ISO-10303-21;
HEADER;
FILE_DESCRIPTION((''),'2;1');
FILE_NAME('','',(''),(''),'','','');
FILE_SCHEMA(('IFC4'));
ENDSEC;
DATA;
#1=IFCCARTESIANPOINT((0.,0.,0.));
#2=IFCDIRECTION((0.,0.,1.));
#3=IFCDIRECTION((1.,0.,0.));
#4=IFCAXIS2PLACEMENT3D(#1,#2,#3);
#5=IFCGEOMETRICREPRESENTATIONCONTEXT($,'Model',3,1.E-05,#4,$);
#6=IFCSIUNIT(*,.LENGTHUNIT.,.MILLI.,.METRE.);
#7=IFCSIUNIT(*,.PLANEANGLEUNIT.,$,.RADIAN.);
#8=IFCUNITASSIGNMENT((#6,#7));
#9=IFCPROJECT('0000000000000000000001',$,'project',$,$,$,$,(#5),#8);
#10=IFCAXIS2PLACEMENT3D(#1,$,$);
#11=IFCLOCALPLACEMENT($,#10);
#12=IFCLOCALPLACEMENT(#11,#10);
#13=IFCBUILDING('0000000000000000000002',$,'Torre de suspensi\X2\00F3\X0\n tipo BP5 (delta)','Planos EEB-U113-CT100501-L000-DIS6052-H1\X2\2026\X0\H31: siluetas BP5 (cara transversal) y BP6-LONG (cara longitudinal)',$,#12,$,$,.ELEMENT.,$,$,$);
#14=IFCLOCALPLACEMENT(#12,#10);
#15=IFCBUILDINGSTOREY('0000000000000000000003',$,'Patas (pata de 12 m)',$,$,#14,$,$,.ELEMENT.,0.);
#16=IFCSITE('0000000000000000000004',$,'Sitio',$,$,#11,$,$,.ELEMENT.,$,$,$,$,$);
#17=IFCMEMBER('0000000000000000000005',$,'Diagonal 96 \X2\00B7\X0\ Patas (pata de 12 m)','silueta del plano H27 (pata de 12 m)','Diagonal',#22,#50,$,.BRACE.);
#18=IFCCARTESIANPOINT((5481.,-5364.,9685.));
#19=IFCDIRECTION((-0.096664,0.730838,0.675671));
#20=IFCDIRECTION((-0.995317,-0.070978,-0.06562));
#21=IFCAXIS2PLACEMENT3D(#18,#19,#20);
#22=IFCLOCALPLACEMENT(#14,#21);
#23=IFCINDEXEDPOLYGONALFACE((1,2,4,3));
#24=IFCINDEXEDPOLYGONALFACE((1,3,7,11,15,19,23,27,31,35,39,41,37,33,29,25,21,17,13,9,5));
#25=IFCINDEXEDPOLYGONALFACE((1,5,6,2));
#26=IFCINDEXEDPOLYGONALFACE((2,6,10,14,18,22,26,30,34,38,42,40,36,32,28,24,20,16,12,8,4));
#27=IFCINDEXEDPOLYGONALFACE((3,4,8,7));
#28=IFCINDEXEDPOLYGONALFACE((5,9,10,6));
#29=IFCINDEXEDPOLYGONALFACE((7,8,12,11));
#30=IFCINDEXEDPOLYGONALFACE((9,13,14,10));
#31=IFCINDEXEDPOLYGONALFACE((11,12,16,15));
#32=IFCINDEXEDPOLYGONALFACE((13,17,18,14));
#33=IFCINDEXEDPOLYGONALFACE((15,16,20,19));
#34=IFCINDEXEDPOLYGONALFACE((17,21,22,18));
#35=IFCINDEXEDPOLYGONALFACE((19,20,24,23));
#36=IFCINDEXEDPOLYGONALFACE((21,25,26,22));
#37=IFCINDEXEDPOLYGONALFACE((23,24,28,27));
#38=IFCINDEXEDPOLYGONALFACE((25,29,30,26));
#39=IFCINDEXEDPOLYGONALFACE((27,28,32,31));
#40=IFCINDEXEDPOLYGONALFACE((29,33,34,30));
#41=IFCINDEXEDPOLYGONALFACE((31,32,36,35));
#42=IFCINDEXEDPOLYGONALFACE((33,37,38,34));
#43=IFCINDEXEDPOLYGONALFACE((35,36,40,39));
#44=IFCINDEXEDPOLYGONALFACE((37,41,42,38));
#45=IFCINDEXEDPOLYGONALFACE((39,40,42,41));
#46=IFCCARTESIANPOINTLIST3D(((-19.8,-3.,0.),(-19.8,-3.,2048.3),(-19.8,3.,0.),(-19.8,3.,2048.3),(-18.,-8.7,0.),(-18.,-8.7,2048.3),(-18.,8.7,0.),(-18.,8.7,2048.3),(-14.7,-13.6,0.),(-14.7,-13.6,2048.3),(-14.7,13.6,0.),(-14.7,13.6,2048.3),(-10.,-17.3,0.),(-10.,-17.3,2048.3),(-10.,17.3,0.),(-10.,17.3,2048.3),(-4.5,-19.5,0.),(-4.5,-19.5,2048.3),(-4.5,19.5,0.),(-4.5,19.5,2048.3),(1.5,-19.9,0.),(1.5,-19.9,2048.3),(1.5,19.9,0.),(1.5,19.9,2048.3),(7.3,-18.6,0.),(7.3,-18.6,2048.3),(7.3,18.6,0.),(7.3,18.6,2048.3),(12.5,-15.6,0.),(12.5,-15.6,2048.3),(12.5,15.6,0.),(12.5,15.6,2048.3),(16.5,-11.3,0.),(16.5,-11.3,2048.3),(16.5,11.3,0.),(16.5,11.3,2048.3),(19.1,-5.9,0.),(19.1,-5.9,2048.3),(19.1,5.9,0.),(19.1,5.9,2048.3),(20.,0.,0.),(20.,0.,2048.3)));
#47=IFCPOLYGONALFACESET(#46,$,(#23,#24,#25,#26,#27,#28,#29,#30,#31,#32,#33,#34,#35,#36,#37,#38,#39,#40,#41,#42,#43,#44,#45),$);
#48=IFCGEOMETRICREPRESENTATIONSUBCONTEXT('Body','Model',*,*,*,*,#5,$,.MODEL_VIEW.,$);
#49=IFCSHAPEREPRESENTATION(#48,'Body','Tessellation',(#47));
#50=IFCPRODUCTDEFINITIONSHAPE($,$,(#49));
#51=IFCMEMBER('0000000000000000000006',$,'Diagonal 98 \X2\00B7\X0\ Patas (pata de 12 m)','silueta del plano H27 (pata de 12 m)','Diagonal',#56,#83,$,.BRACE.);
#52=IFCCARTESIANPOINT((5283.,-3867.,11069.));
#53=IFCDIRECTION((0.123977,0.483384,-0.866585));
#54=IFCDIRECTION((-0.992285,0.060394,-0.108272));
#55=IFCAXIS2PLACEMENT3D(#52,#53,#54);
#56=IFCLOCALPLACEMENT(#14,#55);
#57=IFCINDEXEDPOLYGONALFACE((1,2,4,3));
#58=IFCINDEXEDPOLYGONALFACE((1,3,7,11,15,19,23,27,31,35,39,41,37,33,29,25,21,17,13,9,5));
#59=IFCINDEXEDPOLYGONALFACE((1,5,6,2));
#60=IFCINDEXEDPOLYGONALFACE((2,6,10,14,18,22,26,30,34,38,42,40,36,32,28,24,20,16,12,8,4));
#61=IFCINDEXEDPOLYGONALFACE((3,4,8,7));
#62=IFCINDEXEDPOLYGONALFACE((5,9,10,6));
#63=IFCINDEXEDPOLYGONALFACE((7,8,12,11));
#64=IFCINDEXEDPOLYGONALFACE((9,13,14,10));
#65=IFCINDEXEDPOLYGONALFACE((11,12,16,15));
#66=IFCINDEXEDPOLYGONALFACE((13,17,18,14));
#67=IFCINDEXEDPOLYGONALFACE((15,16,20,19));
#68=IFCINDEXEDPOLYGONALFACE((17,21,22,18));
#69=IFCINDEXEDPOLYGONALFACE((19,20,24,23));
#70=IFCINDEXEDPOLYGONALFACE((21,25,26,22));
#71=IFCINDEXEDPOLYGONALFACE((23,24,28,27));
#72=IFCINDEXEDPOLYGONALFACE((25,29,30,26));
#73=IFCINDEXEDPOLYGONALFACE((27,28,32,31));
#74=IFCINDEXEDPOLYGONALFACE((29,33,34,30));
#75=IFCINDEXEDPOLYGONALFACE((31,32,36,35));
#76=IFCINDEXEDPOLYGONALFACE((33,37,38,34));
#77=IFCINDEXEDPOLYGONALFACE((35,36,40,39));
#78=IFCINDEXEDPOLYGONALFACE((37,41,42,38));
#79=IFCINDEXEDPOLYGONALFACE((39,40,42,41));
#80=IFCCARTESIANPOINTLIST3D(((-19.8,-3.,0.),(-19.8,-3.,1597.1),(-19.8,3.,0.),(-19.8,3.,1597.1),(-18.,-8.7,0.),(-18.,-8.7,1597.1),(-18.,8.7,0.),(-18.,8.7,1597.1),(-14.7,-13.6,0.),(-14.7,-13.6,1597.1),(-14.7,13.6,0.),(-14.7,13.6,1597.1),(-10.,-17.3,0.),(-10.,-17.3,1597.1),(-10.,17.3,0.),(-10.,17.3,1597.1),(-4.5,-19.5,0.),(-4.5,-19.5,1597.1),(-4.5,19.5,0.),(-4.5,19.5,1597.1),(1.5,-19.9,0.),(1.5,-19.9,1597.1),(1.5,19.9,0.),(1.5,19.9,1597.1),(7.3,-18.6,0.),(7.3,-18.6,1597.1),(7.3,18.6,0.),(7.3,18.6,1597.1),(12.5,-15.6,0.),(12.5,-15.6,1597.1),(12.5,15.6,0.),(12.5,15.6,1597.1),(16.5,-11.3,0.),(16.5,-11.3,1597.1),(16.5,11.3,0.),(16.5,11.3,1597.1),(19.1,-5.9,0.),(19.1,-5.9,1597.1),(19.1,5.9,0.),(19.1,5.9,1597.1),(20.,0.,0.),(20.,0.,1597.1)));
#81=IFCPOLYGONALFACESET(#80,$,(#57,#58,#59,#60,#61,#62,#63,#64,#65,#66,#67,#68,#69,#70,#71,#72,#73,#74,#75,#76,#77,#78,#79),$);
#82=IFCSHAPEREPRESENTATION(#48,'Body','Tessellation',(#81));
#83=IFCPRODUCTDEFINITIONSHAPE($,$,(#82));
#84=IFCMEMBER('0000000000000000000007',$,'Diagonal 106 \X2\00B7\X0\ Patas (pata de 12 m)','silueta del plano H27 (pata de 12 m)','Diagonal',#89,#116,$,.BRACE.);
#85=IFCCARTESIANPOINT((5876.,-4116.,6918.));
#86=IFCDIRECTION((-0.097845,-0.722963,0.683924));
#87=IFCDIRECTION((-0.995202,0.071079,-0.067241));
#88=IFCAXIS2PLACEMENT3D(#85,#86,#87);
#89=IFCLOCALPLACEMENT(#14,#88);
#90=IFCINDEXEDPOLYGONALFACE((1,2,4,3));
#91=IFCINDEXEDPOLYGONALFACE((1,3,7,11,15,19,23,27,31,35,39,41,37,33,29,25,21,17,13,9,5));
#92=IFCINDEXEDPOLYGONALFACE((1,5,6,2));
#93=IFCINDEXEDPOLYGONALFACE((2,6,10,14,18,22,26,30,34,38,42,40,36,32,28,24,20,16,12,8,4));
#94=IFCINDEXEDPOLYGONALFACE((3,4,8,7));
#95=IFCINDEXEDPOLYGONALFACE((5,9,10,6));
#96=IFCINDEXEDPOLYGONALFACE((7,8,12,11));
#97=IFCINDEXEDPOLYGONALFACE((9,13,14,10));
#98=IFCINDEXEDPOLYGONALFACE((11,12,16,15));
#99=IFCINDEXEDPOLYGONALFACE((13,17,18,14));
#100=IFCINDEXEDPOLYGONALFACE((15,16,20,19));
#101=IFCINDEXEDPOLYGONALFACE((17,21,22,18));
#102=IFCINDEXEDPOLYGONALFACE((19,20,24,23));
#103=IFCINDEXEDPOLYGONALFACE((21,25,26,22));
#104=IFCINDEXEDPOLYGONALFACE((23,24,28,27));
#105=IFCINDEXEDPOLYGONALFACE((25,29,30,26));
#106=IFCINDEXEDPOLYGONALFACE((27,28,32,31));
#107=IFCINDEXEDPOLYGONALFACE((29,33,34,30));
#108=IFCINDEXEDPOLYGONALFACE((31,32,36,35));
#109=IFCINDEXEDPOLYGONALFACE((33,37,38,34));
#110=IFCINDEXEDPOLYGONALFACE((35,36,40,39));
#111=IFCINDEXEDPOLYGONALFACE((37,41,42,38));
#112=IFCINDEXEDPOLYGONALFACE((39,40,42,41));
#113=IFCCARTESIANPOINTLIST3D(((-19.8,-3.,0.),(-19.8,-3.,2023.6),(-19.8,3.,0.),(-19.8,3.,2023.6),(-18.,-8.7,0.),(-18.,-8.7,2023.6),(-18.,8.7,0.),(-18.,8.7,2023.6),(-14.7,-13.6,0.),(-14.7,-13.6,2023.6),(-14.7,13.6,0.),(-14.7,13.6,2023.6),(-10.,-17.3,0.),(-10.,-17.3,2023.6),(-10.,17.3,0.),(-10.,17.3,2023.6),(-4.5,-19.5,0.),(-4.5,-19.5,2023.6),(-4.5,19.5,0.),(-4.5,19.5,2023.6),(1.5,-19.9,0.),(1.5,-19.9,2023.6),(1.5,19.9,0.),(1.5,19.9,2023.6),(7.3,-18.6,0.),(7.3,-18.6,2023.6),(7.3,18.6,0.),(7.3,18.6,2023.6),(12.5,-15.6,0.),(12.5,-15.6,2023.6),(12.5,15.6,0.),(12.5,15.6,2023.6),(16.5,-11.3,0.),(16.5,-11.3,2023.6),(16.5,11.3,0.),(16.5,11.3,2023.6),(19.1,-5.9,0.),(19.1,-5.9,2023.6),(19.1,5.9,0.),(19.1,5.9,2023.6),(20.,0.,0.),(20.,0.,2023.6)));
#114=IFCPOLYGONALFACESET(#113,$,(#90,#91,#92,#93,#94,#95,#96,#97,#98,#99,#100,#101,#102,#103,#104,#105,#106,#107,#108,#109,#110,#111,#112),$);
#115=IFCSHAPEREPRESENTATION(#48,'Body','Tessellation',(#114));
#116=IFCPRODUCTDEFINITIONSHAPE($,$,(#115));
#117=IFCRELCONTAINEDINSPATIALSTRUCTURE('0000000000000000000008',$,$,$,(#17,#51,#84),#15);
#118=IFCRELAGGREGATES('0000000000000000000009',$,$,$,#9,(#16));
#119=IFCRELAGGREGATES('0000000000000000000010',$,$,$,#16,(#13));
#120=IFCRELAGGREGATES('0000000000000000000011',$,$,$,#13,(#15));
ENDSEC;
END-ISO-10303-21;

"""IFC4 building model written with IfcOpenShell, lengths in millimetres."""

from ifc_helpers import new_model, si_unit, frame, origin, origin_with_axes, place, context, subcontext, project, spatial, circle, extrude, element, save


model = new_model("IFC4")

# Units and contexts
model_context = context("Model", 3, precision=1e-05, world=origin_with_axes())
body_context = subcontext(model_context, "Body", "Model", "MODEL_VIEW")
ifc_project = project(units=[si_unit("LENGTHUNIT", "METRE", prefix="MILLI"), si_unit("PLANEANGLEUNIT", "RADIAN")], contexts=[model_context])

# Site, building, storey
site_placement = place(None, origin())
site = spatial("IfcSite", under=ifc_project, at=site_placement, Name="Sitio", CompositionType="ELEMENT")
building_placement = place(site_placement, origin())
building = spatial("IfcBuilding", under=site, at=building_placement, Name="Torre de suspensión tipo BP5 (delta)", Description="Planos EEB-U113-CT100501-L000-DIS6052-H1…H31: siluetas BP5 (cara transversal) y BP6-LONG (cara longitudinal)", CompositionType="ELEMENT")
storey_placement = place(building_placement, origin())
storey = spatial("IfcBuildingStorey", under=building, at=storey_placement, Name="Patas (pata de 12 m)", CompositionType="ELEMENT", Elevation=0.0)

# Members
member_1_placement = place(storey_placement, frame((5481.0, -5364.0, 9685.0), z_axis=(-0.096664, 0.730838, 0.675671), x_axis=(-0.995317, -0.070978, -0.06562)))
element("IfcMember", 1, at=member_1_placement, inside=storey, Name="Diagonal 96 · Patas (pata de 12 m)", Description="silueta del plano H27 (pata de 12 m)", ObjectType="Diagonal", PredefinedType="BRACE", context=body_context, shape_type="SweptSolid", body=[
    extrude(circle(Radius=20.0), None, (0.0, 0.0, 1.0), 2048.3),
])
member_2_placement = place(storey_placement, frame((5283.0, -3867.0, 11069.0), z_axis=(0.123977, 0.483384, -0.866585), x_axis=(-0.992285, 0.060394, -0.108272)))
element("IfcMember", 2, at=member_2_placement, inside=storey, Name="Diagonal 98 · Patas (pata de 12 m)", Description="silueta del plano H27 (pata de 12 m)", ObjectType="Diagonal", PredefinedType="BRACE", context=body_context, shape_type="SweptSolid", body=[
    extrude(circle(Radius=20.0), None, (0.0, 0.0, 1.0), 1597.1),
])
member_3_placement = place(storey_placement, frame((5876.0, -4116.0, 6918.0), z_axis=(-0.097845, -0.722963, 0.683924), x_axis=(-0.995202, 0.071079, -0.067241)))
element("IfcMember", 3, at=member_3_placement, inside=storey, Name="Diagonal 106 · Patas (pata de 12 m)", Description="silueta del plano H27 (pata de 12 m)", ObjectType="Diagonal", PredefinedType="BRACE", context=body_context, shape_type="SweptSolid", body=[
    extrude(circle(Radius=20.0), None, (0.0, 0.0, 1.0), 2023.6),
])

save(model, "model.ifc")
